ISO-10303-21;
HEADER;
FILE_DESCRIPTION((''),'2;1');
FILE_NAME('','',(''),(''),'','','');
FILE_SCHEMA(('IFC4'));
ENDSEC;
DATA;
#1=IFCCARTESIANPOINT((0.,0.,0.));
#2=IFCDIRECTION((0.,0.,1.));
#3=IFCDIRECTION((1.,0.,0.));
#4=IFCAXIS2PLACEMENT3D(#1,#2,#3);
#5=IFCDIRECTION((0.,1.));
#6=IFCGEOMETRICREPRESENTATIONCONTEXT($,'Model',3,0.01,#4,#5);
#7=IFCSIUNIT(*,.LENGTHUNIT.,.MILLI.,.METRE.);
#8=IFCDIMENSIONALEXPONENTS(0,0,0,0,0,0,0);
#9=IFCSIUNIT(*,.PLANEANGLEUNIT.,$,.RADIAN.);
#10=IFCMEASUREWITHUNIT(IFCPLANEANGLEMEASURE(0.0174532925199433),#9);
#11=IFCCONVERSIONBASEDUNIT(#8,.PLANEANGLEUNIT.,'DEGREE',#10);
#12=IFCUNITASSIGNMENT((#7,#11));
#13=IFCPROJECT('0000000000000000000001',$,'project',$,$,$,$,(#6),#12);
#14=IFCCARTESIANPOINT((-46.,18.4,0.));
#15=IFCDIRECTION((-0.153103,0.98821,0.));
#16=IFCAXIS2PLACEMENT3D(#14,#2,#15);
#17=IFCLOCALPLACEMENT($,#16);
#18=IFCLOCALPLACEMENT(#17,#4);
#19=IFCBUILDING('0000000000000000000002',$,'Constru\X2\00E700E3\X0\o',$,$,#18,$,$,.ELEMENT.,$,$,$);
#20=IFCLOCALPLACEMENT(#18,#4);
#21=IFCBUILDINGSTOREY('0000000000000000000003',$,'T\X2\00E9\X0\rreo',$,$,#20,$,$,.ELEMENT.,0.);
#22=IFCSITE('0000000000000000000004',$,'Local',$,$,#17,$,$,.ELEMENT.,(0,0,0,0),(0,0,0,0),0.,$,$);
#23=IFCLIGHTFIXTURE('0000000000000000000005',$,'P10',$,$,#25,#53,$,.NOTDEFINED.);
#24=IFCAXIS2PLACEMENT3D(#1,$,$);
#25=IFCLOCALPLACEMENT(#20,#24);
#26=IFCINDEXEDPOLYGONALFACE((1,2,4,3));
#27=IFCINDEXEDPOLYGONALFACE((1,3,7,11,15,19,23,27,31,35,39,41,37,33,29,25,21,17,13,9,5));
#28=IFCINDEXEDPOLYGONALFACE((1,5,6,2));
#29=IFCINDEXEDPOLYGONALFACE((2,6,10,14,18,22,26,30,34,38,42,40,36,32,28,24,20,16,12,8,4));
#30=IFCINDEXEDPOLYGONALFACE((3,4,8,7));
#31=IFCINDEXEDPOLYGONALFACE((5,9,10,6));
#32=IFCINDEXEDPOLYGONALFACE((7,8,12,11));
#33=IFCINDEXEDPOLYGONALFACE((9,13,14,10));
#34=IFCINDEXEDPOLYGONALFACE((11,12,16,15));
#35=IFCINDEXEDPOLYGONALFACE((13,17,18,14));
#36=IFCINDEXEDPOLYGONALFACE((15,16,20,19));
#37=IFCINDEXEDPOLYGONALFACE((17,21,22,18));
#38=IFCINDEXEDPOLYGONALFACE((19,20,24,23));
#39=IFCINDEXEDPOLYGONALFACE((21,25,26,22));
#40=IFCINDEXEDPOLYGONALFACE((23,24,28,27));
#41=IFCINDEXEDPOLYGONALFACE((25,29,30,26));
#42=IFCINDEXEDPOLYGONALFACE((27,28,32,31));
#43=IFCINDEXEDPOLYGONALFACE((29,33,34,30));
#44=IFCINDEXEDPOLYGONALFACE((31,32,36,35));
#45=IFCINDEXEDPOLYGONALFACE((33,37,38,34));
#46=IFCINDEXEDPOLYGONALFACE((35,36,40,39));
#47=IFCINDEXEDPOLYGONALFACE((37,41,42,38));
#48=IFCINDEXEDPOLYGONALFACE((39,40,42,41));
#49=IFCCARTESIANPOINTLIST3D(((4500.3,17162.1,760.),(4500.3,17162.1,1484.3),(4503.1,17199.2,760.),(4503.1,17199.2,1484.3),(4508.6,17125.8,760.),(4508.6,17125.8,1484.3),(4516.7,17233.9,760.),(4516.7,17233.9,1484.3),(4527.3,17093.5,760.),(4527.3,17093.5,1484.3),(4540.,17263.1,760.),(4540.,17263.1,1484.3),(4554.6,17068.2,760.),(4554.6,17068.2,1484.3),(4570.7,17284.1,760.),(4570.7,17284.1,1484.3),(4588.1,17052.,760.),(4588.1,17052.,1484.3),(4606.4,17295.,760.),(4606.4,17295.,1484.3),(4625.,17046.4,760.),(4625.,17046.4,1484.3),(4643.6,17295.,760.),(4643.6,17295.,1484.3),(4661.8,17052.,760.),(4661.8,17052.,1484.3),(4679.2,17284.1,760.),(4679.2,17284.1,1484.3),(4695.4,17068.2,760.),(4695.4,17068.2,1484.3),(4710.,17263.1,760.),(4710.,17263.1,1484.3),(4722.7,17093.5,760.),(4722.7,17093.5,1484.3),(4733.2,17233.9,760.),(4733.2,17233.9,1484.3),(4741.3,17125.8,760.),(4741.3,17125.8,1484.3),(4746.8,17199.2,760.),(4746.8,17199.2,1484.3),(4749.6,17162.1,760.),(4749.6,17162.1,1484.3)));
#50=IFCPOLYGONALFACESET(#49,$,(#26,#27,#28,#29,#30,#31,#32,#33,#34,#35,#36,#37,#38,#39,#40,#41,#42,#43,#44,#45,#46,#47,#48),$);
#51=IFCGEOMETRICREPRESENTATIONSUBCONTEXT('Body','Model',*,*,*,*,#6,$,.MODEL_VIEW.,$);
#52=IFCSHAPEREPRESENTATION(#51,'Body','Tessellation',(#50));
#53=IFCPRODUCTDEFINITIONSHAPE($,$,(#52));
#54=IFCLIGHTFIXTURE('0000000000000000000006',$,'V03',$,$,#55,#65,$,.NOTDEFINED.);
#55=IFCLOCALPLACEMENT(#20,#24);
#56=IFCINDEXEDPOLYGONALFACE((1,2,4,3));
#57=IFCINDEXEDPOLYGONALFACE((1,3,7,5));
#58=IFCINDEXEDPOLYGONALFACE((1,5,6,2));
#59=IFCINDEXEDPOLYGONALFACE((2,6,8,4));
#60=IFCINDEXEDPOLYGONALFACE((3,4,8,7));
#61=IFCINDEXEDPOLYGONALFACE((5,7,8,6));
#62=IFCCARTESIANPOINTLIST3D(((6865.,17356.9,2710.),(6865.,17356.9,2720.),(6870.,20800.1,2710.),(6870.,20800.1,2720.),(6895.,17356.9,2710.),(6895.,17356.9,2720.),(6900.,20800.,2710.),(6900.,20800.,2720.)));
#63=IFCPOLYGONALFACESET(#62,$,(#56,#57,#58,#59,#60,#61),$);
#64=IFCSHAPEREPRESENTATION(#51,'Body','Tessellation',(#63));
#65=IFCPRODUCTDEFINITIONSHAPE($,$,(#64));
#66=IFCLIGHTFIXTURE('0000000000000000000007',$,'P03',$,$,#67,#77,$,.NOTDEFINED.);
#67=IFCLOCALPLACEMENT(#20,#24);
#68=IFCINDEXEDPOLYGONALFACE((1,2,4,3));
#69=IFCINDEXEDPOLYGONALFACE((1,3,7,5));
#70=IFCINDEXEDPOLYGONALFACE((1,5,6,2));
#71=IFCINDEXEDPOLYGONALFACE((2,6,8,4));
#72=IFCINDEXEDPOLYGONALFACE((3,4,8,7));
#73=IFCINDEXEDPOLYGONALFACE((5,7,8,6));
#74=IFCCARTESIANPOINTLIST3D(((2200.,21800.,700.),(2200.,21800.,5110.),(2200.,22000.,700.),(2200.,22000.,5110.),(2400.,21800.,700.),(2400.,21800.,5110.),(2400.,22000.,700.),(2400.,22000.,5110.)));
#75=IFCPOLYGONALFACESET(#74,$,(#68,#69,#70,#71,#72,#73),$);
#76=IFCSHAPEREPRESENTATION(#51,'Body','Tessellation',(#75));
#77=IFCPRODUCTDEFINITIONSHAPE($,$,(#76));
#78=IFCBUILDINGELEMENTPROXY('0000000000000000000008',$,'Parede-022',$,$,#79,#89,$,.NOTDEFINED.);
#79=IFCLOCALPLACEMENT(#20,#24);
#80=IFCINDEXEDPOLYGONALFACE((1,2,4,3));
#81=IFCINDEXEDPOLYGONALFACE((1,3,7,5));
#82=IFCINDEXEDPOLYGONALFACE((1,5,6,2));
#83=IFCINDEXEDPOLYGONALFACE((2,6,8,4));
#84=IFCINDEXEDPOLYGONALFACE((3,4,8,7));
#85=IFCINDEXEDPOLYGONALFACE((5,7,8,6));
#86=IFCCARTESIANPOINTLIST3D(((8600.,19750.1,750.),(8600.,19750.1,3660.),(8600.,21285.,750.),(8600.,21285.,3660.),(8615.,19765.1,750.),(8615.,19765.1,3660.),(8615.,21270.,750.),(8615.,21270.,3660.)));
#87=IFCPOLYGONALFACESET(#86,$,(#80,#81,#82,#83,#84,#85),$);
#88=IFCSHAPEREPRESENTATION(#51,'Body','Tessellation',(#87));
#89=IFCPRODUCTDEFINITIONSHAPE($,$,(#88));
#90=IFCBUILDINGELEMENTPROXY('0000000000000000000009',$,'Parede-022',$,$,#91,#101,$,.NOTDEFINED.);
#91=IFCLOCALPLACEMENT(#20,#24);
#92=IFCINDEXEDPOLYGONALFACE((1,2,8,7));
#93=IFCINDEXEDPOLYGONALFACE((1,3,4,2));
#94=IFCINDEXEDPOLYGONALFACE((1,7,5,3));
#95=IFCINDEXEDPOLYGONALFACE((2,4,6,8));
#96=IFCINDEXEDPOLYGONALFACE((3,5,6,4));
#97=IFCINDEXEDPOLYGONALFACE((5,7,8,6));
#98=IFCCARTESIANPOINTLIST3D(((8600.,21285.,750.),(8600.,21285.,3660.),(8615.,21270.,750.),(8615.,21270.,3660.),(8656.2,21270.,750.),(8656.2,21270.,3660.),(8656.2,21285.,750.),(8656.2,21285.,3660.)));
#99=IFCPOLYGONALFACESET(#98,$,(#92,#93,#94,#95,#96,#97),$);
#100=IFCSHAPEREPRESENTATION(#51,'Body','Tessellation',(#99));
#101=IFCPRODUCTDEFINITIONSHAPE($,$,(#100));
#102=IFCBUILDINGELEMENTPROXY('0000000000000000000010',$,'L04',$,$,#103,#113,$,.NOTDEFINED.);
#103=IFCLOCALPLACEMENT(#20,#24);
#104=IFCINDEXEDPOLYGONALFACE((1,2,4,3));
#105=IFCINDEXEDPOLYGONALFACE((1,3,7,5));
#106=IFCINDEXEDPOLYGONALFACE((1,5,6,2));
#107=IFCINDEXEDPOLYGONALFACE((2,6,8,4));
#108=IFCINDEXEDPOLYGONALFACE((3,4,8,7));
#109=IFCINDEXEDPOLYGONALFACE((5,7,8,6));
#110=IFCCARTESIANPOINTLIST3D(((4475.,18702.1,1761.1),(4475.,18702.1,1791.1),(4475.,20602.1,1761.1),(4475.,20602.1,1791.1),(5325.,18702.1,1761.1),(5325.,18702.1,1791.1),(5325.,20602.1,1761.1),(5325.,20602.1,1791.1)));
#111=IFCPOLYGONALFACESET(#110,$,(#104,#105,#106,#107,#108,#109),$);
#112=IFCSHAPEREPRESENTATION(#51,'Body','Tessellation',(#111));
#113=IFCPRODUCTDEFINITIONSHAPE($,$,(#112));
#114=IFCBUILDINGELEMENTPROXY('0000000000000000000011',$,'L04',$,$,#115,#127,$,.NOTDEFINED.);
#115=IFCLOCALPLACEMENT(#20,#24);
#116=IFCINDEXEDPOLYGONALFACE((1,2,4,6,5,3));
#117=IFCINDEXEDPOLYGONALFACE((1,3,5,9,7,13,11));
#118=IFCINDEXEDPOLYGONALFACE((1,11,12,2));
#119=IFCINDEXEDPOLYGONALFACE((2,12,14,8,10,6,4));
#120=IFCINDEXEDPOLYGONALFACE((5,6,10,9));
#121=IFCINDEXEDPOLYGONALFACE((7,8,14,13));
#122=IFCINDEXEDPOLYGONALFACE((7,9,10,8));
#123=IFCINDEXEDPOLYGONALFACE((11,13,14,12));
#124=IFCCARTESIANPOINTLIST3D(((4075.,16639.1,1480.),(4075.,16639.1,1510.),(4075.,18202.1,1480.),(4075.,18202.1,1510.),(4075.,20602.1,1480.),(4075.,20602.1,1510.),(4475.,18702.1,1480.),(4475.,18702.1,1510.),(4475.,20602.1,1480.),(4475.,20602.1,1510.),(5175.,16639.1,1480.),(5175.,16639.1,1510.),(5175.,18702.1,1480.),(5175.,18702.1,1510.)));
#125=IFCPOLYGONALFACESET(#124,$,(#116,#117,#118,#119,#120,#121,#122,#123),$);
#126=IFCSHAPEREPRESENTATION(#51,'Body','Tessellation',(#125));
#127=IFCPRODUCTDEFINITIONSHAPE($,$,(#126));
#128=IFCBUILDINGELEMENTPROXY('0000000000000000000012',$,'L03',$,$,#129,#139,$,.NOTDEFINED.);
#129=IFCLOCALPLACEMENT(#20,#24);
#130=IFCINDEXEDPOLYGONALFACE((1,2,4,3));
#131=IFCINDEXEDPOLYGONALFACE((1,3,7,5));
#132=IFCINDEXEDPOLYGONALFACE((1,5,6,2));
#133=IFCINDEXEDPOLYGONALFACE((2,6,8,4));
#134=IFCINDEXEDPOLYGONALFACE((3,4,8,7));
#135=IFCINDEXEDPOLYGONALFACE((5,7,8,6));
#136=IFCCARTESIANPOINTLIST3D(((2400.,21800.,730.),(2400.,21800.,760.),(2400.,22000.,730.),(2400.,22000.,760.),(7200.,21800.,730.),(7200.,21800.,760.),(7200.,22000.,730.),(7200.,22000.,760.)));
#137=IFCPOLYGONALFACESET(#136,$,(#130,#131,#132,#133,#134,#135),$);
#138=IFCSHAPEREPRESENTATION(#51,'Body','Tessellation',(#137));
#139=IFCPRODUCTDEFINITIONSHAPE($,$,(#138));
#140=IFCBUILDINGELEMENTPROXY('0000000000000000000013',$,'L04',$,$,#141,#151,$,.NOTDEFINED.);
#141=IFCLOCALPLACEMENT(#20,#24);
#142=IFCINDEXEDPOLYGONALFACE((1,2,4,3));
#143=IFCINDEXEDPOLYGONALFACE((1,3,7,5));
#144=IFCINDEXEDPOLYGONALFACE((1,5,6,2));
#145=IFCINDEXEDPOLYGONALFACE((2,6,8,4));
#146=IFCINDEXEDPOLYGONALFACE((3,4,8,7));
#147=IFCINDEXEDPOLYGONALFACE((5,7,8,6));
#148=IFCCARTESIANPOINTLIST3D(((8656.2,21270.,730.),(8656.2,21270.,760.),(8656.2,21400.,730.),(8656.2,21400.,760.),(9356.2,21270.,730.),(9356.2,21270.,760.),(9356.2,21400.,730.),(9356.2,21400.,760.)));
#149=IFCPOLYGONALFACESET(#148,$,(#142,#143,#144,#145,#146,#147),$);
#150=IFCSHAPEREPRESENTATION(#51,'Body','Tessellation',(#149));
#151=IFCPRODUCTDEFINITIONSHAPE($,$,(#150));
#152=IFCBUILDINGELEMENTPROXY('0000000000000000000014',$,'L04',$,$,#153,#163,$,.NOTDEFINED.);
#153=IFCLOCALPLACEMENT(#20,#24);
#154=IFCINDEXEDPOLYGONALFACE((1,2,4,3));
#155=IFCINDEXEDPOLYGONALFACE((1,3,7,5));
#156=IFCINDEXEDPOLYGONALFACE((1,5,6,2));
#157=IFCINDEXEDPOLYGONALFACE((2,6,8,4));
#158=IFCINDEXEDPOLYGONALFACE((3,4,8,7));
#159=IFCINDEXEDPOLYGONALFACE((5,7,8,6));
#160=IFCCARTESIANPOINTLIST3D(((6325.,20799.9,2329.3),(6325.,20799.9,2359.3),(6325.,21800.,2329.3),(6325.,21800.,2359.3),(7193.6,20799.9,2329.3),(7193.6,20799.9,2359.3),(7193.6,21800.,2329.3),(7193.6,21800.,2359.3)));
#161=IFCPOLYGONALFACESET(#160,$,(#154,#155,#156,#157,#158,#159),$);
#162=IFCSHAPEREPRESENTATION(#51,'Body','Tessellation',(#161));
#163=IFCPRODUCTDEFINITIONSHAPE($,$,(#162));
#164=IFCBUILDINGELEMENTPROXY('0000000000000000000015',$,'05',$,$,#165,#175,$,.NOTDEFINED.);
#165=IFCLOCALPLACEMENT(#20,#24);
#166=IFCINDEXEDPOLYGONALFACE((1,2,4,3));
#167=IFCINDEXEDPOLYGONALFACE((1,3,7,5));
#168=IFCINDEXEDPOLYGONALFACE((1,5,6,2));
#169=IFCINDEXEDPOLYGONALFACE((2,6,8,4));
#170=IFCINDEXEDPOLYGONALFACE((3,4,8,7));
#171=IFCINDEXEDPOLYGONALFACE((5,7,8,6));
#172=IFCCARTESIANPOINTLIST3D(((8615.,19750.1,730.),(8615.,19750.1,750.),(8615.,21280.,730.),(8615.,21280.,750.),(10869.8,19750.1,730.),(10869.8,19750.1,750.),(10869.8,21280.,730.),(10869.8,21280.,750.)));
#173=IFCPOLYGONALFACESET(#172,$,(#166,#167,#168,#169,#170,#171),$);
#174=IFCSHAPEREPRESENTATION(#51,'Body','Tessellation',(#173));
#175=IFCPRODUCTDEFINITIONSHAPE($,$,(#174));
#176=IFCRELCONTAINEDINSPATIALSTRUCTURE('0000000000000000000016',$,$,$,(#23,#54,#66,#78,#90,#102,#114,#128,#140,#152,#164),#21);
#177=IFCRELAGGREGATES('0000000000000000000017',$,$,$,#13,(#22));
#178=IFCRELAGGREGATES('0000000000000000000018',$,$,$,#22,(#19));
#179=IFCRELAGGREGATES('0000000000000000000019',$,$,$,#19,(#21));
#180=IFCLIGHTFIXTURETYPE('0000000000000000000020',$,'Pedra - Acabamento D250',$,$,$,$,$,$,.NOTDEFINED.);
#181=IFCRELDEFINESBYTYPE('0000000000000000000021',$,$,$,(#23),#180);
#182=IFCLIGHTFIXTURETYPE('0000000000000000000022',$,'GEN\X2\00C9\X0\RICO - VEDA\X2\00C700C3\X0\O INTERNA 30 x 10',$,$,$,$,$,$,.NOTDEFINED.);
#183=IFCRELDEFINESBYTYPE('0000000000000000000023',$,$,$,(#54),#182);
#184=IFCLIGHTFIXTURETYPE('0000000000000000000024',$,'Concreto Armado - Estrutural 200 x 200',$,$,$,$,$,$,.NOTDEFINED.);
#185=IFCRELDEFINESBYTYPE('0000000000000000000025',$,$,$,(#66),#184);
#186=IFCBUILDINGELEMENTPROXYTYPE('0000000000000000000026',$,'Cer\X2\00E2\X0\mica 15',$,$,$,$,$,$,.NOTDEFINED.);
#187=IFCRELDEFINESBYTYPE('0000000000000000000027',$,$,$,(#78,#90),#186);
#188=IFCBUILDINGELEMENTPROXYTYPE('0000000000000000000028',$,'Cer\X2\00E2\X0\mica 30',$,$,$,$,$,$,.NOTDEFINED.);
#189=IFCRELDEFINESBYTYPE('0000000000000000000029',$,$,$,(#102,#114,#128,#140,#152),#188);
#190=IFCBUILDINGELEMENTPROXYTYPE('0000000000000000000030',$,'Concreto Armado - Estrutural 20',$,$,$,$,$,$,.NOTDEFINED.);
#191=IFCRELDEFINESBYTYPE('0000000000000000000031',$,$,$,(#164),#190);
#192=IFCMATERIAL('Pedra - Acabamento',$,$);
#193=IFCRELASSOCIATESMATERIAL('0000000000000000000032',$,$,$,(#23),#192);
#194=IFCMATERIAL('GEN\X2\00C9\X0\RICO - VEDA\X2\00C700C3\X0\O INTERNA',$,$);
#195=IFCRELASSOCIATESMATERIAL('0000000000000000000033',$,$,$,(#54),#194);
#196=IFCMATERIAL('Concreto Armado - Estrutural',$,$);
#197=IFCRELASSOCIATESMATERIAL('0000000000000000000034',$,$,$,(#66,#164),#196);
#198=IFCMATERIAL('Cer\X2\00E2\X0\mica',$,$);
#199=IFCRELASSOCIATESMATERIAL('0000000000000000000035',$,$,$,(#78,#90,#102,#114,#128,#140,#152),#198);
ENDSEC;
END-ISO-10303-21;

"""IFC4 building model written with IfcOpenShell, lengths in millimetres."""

from ifc_helpers import new_model, entity, si_unit, converted_unit, direction, frame, frame_2d, origin_with_axes, origin_2d_with_axis, place, context, subcontext, project, spatial, line, indexed_curve, rectangle, circle, outline, extrude, material, type_object, element, save


model = new_model("IFC4")

# Units and contexts
model_context = context("Model", 3, precision=0.01, world=origin_with_axes(), true_north=direction((0.0, 1.0)))
body_context = subcontext(model_context, "Body", "Model", "MODEL_VIEW")
ifc_project = project(units=[si_unit("LENGTHUNIT", "METRE", prefix="MILLI"), converted_unit("PLANEANGLEUNIT", "DEGREE", entity("IfcPlaneAngleMeasure", 0.0174532925199433), si_unit("PLANEANGLEUNIT", "RADIAN"), dimensions=[0, 0, 0, 0, 0, 0, 0])], contexts=[model_context])

# Site, building, storey
site_placement = place(None, frame((-46.0, 18.4, 0.0), z_axis=(0.0, 0.0, 1.0), x_axis=(-0.153103, 0.98821, 0.0)))
site = spatial("IfcSite", under=ifc_project, at=site_placement, Name="Local", CompositionType="ELEMENT", RefLatitude=(0, 0, 0, 0), RefLongitude=(0, 0, 0, 0), RefElevation=0.0)
building_placement = place(site_placement, origin_with_axes())
building = spatial("IfcBuilding", under=site, at=building_placement, Name="Construção", CompositionType="ELEMENT")
storey_placement = place(building_placement, origin_with_axes())
storey = spatial("IfcBuildingStorey", under=building, at=storey_placement, Name="Térreo", CompositionType="ELEMENT", Elevation=0.0)

# Shared definitions
ifc_material_1 = material(Name="GENÉRICO - VEDAÇÃO INTERNA")

# Light fixtures
ifc_material_2 = material(Name="Pedra - Acabamento")
light_fixture_type_1 = type_object("IfcLightFixtureType", Name="Pedra - Acabamento D250", PredefinedType="NOTDEFINED")
light_fixture_1_placement = place(storey_placement, frame((4625.0, 17171.4, 760.0), z_axis=(0.0, 0.0, 1.0), x_axis=(0.0, -1.0, 0.0)))
element("IfcLightFixture", 1, at=light_fixture_1_placement, inside=storey, type_object=light_fixture_type_1, material=ifc_material_2, Name="P10", PredefinedType="NOTDEFINED", context=body_context, shape_type="SweptSolid", body=[
    extrude(circle(Radius=125.0, at=origin_2d_with_axis()), origin_with_axes(), (0.0, 0.0, 1.0), 724.3),
])
light_fixture_type_2 = type_object("IfcLightFixtureType", Name="GENÉRICO - VEDAÇÃO INTERNA 30 x 10", PredefinedType="NOTDEFINED")
light_fixture_2_placement = place(storey_placement, frame((6895.0, 17356.9, 2720.0), z_axis=(0.0, 0.0, 1.0), x_axis=(0.999999, -0.001452, 0.0)))
element("IfcLightFixture", 2, at=light_fixture_2_placement, inside=storey, type_object=light_fixture_type_2, material=ifc_material_1, Name="V03", PredefinedType="NOTDEFINED", context=body_context, shape_type="SweptSolid", body=[
    extrude(rectangle(XDim=10.0, YDim=30.0, at=frame_2d((-5.0, -15.0), x_axis=(1.0, 0.0))), frame((0.0, 0.0, 0.0), z_axis=(0.0, 1.0, 0.0), x_axis=(0.0, 0.0, 1.0)), (0.0, 0.0, 1.0), 3443.1),
])
ifc_material_3 = material(Name="Concreto Armado - Estrutural")
light_fixture_type_3 = type_object("IfcLightFixtureType", Name="Concreto Armado - Estrutural 200 x 200", PredefinedType="NOTDEFINED")
light_fixture_3_placement = place(storey_placement, frame((2300.0, 21900.0, 700.0), z_axis=(0.0, 0.0, 1.0), x_axis=(1.0, 0.0, 0.0)))
element("IfcLightFixture", 3, at=light_fixture_3_placement, inside=storey, type_object=light_fixture_type_3, material=ifc_material_3, Name="P03", PredefinedType="NOTDEFINED", context=body_context, shape_type="SweptSolid", body=[
    extrude(rectangle(XDim=200.0, YDim=200.0, at=origin_2d_with_axis()), origin_with_axes(), (0.0, 0.0, 1.0), 4410.0),
])

# Building element proxies
ifc_material_4 = material(Name="Cerâmica")
building_element_proxy_type_1 = type_object("IfcBuildingElementProxyType", Name="Cerâmica 15", PredefinedType="NOTDEFINED")
proxy_1_placement = place(storey_placement, frame((8600.0, 19750.1, 750.0), z_axis=(0.0, 0.0, 1.0), x_axis=(0.0, 1.0, 0.0)))
element("IfcBuildingElementProxy", 4, at=proxy_1_placement, inside=storey, type_object=building_element_proxy_type_1, material=ifc_material_4, Name="Parede-022", PredefinedType="NOTDEFINED", context=body_context, shape_type="SweptSolid", body=[
    extrude(outline(indexed_curve([(15.0, -15.0), (1520.0, -15.0), (1535.0, 0.0), (0.0, 0.0)], segments=[line(1, 2, 3, 4, 1)])), origin_with_axes(), (0.0, 0.0, 1.0), 2910.0),
])
proxy_2_placement = place(storey_placement, frame((8656.2, 21285.0, 750.0), z_axis=(0.0, 0.0, 1.0), x_axis=(-1.0, 0.0, 0.0)))
element("IfcBuildingElementProxy", 5, at=proxy_2_placement, inside=storey, type_object=building_element_proxy_type_1, material=ifc_material_4, Name="Parede-022", PredefinedType="NOTDEFINED", context=body_context, shape_type="SweptSolid", body=[
    extrude(outline(indexed_curve([(0.0, 0.0), (56.2, 0.0), (41.2, 15.0), (0.0, 15.0)], segments=[line(1, 2, 3, 4, 1)])), origin_with_axes(), (0.0, 0.0, 1.0), 2910.0),
])
building_element_proxy_type_2 = type_object("IfcBuildingElementProxyType", Name="Cerâmica 30", PredefinedType="NOTDEFINED")
proxy_3_placement = place(storey_placement, frame((4475.0, 18702.1, 1791.1), z_axis=(0.0, 0.0, 1.0), x_axis=(1.0, 0.0, 0.0)))
element("IfcBuildingElementProxy", 6, at=proxy_3_placement, inside=storey, type_object=building_element_proxy_type_2, material=ifc_material_4, Name="L04", PredefinedType="NOTDEFINED", context=body_context, shape_type="SweptSolid", body=[
    extrude(outline(indexed_curve([(0.0, 0.0), (850.0, 0.0), (850.0, 1900.0), (0.0, 1900.0)], segments=[line(1, 2, 3, 4, 1)])), frame((0.0, 0.0, -30.0), z_axis=(0.0, 0.0, 1.0), x_axis=(1.0, 0.0, 0.0)), (0.0, 0.0, 1.0), 30.0),
])
proxy_4_placement = place(storey_placement, frame((4075.0, 18202.1, 1510.0), z_axis=(0.0, 0.0, 1.0), x_axis=(1.0, 0.0, 0.0)))
element("IfcBuildingElementProxy", 7, at=proxy_4_placement, inside=storey, type_object=building_element_proxy_type_2, material=ifc_material_4, Name="L04", PredefinedType="NOTDEFINED", context=body_context, shape_type="SweptSolid", body=[
    extrude(outline(indexed_curve([(0.0, 0.0), (0.0, -1563.0), (1100.0, -1563.0), (1100.0, 500.0), (400.0, 500.0), (400.0, 2400.0), (0.0, 2400.0)], segments=[line(1, 2, 3, 4, 5, 6, 7, 1)])), frame((0.0, 0.0, -30.0), z_axis=(0.0, 0.0, 1.0), x_axis=(1.0, 0.0, 0.0)), (0.0, 0.0, 1.0), 30.0),
])
proxy_5_placement = place(storey_placement, frame((2400.0, 22000.0, 760.0), z_axis=(0.0, 0.0, 1.0), x_axis=(1.0, 0.0, 0.0)))
element("IfcBuildingElementProxy", 8, at=proxy_5_placement, inside=storey, type_object=building_element_proxy_type_2, material=ifc_material_4, Name="L03", PredefinedType="NOTDEFINED", context=body_context, shape_type="SweptSolid", body=[
    extrude(outline(indexed_curve([(0.0, 0.0), (0.0, -200.0), (4800.0, -200.0), (4800.0, 0.0)], segments=[line(1, 2, 3, 4, 1)])), frame((0.0, 0.0, -30.0), z_axis=(0.0, 0.0, 1.0), x_axis=(1.0, 0.0, 0.0)), (0.0, 0.0, 1.0), 30.0),
])
proxy_6_placement = place(storey_placement, frame((8656.2, 21400.0, 760.0), z_axis=(0.0, 0.0, 1.0), x_axis=(1.0, 0.0, 0.0)))
element("IfcBuildingElementProxy", 9, at=proxy_6_placement, inside=storey, type_object=building_element_proxy_type_2, material=ifc_material_4, Name="L04", PredefinedType="NOTDEFINED", context=body_context, shape_type="SweptSolid", body=[
    extrude(outline(indexed_curve([(0.0, 0.0), (0.0, -130.0), (700.0, -130.0), (700.0, 0.0)], segments=[line(1, 2, 3, 4, 1)])), frame((0.0, 0.0, -30.0), z_axis=(0.0, 0.0, 1.0), x_axis=(1.0, 0.0, 0.0)), (0.0, 0.0, 1.0), 30.0),
])
proxy_7_placement = place(storey_placement, frame((6325.0, 20799.9, 2359.3), z_axis=(0.0, 0.0, 1.0), x_axis=(1.0, 0.0, 0.0)))
element("IfcBuildingElementProxy", 10, at=proxy_7_placement, inside=storey, type_object=building_element_proxy_type_2, material=ifc_material_4, Name="L04", PredefinedType="NOTDEFINED", context=body_context, shape_type="SweptSolid", body=[
    extrude(outline(indexed_curve([(0.0, 0.0), (868.6, 0.0), (868.6, 1000.1), (0.0, 1000.1)], segments=[line(1, 2, 3, 4, 1)])), frame((0.0, 0.0, -30.0), z_axis=(0.0, 0.0, 1.0), x_axis=(1.0, 0.0, 0.0)), (0.0, 0.0, 1.0), 30.0),
])
building_element_proxy_type_3 = type_object("IfcBuildingElementProxyType", Name="Concreto Armado - Estrutural 20", PredefinedType="NOTDEFINED")
proxy_8_placement = place(storey_placement, frame((8615.0, 19750.1, 750.0), z_axis=(0.0, 0.0, 1.0), x_axis=(1.0, 0.0, 0.0)))
element("IfcBuildingElementProxy", 11, at=proxy_8_placement, inside=storey, type_object=building_element_proxy_type_3, material=ifc_material_3, Name="05", PredefinedType="NOTDEFINED", context=body_context, shape_type="SweptSolid", body=[
    extrude(outline(indexed_curve([(0.0, 0.0), (2254.9, 0.0), (2254.9, 1530.0), (0.0, 1530.0)], segments=[line(1, 2, 3, 4, 1)])), frame((0.0, 0.0, -20.0), z_axis=(0.0, 0.0, 1.0), x_axis=(1.0, 0.0, 0.0)), (0.0, 0.0, 1.0), 20.0),
])

save(model, "model.ifc")
